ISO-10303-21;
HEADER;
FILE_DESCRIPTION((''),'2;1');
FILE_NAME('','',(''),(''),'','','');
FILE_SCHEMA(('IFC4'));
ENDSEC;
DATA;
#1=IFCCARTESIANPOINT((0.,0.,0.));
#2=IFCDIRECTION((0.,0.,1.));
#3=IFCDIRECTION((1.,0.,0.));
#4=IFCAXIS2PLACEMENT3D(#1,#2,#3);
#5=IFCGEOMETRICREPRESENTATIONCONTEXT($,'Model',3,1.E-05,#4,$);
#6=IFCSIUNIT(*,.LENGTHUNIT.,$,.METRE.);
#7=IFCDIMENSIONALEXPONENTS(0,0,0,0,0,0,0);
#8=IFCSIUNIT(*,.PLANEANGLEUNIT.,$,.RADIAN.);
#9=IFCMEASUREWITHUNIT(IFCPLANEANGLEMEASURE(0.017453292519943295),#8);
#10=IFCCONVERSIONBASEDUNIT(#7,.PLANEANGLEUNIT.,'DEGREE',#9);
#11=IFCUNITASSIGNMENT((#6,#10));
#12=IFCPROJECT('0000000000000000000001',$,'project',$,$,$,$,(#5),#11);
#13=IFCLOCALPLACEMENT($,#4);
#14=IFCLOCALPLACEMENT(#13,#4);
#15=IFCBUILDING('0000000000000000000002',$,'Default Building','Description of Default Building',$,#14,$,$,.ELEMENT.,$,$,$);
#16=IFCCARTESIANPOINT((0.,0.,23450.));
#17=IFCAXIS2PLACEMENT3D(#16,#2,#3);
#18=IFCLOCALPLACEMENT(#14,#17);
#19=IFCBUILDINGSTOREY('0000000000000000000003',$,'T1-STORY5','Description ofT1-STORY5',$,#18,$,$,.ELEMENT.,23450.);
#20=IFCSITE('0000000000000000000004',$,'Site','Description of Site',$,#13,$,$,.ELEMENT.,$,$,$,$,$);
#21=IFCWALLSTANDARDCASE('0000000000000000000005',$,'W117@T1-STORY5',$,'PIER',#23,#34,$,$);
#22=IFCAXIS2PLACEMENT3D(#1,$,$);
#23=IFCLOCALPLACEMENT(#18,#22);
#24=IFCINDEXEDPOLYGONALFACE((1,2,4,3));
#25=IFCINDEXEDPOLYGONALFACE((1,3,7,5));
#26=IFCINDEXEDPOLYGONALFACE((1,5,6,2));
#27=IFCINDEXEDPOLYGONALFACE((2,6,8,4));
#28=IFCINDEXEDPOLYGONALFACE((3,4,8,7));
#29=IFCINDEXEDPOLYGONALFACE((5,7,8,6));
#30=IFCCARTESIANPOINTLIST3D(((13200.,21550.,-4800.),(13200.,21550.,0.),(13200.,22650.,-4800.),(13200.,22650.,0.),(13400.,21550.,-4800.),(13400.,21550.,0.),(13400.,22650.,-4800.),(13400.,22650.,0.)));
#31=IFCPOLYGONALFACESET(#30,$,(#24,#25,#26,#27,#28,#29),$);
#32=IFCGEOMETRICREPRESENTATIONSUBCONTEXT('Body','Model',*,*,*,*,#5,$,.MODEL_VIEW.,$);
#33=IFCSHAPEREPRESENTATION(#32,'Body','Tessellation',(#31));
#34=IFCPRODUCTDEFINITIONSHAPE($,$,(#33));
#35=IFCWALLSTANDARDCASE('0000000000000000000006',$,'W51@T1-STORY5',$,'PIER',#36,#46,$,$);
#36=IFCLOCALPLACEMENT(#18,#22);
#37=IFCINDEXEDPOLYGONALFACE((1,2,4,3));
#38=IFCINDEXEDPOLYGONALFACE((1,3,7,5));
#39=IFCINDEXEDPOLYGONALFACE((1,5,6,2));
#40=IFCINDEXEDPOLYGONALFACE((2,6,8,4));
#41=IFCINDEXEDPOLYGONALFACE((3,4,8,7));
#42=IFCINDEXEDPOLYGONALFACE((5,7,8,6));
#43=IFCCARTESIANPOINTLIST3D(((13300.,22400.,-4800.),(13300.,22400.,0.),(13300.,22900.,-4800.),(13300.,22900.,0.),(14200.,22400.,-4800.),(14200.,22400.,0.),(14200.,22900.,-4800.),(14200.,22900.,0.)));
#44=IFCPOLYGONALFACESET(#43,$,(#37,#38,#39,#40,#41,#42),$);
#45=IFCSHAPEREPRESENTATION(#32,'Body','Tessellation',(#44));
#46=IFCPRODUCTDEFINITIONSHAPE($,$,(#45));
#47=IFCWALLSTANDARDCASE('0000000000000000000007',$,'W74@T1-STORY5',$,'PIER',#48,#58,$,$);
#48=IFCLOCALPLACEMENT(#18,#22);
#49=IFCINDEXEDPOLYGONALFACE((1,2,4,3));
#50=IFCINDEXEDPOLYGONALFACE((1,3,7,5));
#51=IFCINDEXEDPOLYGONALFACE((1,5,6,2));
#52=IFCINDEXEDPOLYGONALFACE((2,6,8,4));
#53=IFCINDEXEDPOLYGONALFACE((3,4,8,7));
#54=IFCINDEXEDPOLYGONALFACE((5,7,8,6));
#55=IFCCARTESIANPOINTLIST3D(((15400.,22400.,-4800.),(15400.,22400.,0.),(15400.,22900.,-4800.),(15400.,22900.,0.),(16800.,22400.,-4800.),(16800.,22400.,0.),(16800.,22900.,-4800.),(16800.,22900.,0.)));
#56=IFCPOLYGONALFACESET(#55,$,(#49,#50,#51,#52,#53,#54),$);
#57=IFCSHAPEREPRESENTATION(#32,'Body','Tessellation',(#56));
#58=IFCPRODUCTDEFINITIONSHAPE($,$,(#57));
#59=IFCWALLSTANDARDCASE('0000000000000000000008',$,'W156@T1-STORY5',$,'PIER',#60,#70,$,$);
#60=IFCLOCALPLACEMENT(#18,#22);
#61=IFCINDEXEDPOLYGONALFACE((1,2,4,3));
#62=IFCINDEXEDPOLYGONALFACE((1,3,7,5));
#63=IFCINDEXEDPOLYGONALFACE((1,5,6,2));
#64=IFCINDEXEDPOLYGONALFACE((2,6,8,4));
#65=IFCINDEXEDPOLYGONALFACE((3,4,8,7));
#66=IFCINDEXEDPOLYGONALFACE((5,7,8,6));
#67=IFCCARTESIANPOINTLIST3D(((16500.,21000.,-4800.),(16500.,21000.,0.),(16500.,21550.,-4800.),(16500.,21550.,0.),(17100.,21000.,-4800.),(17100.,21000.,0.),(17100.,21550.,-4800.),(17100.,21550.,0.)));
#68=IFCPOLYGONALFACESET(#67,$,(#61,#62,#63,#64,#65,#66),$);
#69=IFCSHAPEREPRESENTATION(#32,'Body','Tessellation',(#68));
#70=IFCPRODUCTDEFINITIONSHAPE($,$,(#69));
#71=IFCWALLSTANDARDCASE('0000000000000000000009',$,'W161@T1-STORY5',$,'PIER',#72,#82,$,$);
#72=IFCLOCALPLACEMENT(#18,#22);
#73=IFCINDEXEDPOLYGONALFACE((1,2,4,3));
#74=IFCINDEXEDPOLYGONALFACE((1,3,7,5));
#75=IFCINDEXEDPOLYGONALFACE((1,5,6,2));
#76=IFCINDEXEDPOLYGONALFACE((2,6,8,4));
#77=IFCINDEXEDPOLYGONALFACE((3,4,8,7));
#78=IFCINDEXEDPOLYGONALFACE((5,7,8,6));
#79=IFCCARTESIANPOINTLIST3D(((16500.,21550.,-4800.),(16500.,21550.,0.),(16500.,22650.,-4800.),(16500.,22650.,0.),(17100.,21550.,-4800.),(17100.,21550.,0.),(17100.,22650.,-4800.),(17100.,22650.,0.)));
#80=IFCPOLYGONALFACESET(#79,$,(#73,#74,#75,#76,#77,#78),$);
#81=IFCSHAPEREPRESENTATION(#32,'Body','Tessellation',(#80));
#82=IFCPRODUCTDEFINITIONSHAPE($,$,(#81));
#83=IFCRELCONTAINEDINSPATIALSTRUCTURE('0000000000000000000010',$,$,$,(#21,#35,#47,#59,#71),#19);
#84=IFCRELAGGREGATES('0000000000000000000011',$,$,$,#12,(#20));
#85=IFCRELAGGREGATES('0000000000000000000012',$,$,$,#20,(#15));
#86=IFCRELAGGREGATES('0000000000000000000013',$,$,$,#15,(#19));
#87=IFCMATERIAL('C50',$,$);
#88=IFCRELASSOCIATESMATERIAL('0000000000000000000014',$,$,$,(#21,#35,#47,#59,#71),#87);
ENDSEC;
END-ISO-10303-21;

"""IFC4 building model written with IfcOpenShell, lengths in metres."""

from ifc_helpers import new_model, entity, si_unit, converted_unit, frame, origin_with_axes, place, context, subcontext, project, spatial, indexed_curve, outline, extrude, material, element, save


model = new_model("IFC4")

# Units and contexts
model_context = context("Model", 3, precision=1e-05, world=origin_with_axes())
body_context = subcontext(model_context, "Body", "Model", "MODEL_VIEW")
ifc_project = project(units=[si_unit("LENGTHUNIT", "METRE"), converted_unit("PLANEANGLEUNIT", "DEGREE", entity("IfcPlaneAngleMeasure", 0.017453292519943295), si_unit("PLANEANGLEUNIT", "RADIAN"), dimensions=[0, 0, 0, 0, 0, 0, 0])], contexts=[model_context])

# Site, building, storey
site_placement = place(None, origin_with_axes())
site = spatial("IfcSite", under=ifc_project, at=site_placement, Name="Site", Description="Description of Site", CompositionType="ELEMENT")
building_placement = place(site_placement, origin_with_axes())
building = spatial("IfcBuilding", under=site, at=building_placement, Name="Default Building", Description="Description of Default Building", CompositionType="ELEMENT")
storey_placement = place(building_placement, frame((0.0, 0.0, 23450.0), z_axis=(0.0, 0.0, 1.0), x_axis=(1.0, 0.0, 0.0)))
storey = spatial("IfcBuildingStorey", under=building, at=storey_placement, Name="T1-STORY5", Description="Description ofT1-STORY5", CompositionType="ELEMENT", Elevation=23450.0)

# Shared definitions
ifc_material_1 = material(Name="C50")

# Walls
wall_1_placement = place(storey_placement, frame((13300.0, 21550.0, -4800.0), z_axis=(0.0, 0.0, 1.0), x_axis=(0.0, 1.0, 0.0)))
element("IfcWallStandardCase", 1, at=wall_1_placement, inside=storey, material=ifc_material_1, Name="W117@T1-STORY5", ObjectType="PIER", context=body_context, shape_type="SweptSolid", body=[
    extrude(outline(indexed_curve([(0.0, -100.0), (0.0, 100.0), (1100.0, 100.0), (1100.0, -100.0), (0.0, -100.0)], self_intersect=False)), origin_with_axes(), (0.0, 0.0, 1.0), 4800.0),
])
wall_2_placement = place(storey_placement, frame((13300.0, 22650.0, -4800.0), z_axis=(0.0, 0.0, 1.0), x_axis=(1.0, 0.0, 0.0)))
element("IfcWallStandardCase", 2, at=wall_2_placement, inside=storey, material=ifc_material_1, Name="W51@T1-STORY5", ObjectType="PIER", context=body_context, shape_type="SweptSolid", body=[
    extrude(outline(indexed_curve([(0.0, -250.0), (0.0, 250.0), (900.0, 250.0), (900.0, -250.0), (0.0, -250.0)], self_intersect=False)), origin_with_axes(), (0.0, 0.0, 1.0), 4800.0),
])
wall_3_placement = place(storey_placement, frame((15400.0, 22650.0, -4800.0), z_axis=(0.0, 0.0, 1.0), x_axis=(1.0, 0.0, 0.0)))
element("IfcWallStandardCase", 3, at=wall_3_placement, inside=storey, material=ifc_material_1, Name="W74@T1-STORY5", ObjectType="PIER", context=body_context, shape_type="SweptSolid", body=[
    extrude(outline(indexed_curve([(0.0, -250.0), (0.0, 250.0), (1400.0, 250.0), (1400.0, -250.0), (0.0, -250.0)], self_intersect=False)), origin_with_axes(), (0.0, 0.0, 1.0), 4800.0),
])
wall_4_placement = place(storey_placement, frame((16800.0, 21000.0, -4800.0), z_axis=(0.0, 0.0, 1.0), x_axis=(0.0, 1.0, 0.0)))
element("IfcWallStandardCase", 4, at=wall_4_placement, inside=storey, material=ifc_material_1, Name="W156@T1-STORY5", ObjectType="PIER", context=body_context, shape_type="SweptSolid", body=[
    extrude(outline(indexed_curve([(0.0, -300.0), (0.0, 300.0), (550.0, 300.0), (550.0, -300.0), (0.0, -300.0)], self_intersect=False)), origin_with_axes(), (0.0, 0.0, 1.0), 4800.0),
])
wall_5_placement = place(storey_placement, frame((16800.0, 21550.0, -4800.0), z_axis=(0.0, 0.0, 1.0), x_axis=(0.0, 1.0, 0.0)))
element("IfcWallStandardCase", 5, at=wall_5_placement, inside=storey, material=ifc_material_1, Name="W161@T1-STORY5", ObjectType="PIER", context=body_context, shape_type="SweptSolid", body=[
    extrude(outline(indexed_curve([(0.0, -300.0), (0.0, 300.0), (1100.0, 300.0), (1100.0, -300.0), (0.0, -300.0)], self_intersect=False)), origin_with_axes(), (0.0, 0.0, 1.0), 4800.0),
])

save(model, "model.ifc")
